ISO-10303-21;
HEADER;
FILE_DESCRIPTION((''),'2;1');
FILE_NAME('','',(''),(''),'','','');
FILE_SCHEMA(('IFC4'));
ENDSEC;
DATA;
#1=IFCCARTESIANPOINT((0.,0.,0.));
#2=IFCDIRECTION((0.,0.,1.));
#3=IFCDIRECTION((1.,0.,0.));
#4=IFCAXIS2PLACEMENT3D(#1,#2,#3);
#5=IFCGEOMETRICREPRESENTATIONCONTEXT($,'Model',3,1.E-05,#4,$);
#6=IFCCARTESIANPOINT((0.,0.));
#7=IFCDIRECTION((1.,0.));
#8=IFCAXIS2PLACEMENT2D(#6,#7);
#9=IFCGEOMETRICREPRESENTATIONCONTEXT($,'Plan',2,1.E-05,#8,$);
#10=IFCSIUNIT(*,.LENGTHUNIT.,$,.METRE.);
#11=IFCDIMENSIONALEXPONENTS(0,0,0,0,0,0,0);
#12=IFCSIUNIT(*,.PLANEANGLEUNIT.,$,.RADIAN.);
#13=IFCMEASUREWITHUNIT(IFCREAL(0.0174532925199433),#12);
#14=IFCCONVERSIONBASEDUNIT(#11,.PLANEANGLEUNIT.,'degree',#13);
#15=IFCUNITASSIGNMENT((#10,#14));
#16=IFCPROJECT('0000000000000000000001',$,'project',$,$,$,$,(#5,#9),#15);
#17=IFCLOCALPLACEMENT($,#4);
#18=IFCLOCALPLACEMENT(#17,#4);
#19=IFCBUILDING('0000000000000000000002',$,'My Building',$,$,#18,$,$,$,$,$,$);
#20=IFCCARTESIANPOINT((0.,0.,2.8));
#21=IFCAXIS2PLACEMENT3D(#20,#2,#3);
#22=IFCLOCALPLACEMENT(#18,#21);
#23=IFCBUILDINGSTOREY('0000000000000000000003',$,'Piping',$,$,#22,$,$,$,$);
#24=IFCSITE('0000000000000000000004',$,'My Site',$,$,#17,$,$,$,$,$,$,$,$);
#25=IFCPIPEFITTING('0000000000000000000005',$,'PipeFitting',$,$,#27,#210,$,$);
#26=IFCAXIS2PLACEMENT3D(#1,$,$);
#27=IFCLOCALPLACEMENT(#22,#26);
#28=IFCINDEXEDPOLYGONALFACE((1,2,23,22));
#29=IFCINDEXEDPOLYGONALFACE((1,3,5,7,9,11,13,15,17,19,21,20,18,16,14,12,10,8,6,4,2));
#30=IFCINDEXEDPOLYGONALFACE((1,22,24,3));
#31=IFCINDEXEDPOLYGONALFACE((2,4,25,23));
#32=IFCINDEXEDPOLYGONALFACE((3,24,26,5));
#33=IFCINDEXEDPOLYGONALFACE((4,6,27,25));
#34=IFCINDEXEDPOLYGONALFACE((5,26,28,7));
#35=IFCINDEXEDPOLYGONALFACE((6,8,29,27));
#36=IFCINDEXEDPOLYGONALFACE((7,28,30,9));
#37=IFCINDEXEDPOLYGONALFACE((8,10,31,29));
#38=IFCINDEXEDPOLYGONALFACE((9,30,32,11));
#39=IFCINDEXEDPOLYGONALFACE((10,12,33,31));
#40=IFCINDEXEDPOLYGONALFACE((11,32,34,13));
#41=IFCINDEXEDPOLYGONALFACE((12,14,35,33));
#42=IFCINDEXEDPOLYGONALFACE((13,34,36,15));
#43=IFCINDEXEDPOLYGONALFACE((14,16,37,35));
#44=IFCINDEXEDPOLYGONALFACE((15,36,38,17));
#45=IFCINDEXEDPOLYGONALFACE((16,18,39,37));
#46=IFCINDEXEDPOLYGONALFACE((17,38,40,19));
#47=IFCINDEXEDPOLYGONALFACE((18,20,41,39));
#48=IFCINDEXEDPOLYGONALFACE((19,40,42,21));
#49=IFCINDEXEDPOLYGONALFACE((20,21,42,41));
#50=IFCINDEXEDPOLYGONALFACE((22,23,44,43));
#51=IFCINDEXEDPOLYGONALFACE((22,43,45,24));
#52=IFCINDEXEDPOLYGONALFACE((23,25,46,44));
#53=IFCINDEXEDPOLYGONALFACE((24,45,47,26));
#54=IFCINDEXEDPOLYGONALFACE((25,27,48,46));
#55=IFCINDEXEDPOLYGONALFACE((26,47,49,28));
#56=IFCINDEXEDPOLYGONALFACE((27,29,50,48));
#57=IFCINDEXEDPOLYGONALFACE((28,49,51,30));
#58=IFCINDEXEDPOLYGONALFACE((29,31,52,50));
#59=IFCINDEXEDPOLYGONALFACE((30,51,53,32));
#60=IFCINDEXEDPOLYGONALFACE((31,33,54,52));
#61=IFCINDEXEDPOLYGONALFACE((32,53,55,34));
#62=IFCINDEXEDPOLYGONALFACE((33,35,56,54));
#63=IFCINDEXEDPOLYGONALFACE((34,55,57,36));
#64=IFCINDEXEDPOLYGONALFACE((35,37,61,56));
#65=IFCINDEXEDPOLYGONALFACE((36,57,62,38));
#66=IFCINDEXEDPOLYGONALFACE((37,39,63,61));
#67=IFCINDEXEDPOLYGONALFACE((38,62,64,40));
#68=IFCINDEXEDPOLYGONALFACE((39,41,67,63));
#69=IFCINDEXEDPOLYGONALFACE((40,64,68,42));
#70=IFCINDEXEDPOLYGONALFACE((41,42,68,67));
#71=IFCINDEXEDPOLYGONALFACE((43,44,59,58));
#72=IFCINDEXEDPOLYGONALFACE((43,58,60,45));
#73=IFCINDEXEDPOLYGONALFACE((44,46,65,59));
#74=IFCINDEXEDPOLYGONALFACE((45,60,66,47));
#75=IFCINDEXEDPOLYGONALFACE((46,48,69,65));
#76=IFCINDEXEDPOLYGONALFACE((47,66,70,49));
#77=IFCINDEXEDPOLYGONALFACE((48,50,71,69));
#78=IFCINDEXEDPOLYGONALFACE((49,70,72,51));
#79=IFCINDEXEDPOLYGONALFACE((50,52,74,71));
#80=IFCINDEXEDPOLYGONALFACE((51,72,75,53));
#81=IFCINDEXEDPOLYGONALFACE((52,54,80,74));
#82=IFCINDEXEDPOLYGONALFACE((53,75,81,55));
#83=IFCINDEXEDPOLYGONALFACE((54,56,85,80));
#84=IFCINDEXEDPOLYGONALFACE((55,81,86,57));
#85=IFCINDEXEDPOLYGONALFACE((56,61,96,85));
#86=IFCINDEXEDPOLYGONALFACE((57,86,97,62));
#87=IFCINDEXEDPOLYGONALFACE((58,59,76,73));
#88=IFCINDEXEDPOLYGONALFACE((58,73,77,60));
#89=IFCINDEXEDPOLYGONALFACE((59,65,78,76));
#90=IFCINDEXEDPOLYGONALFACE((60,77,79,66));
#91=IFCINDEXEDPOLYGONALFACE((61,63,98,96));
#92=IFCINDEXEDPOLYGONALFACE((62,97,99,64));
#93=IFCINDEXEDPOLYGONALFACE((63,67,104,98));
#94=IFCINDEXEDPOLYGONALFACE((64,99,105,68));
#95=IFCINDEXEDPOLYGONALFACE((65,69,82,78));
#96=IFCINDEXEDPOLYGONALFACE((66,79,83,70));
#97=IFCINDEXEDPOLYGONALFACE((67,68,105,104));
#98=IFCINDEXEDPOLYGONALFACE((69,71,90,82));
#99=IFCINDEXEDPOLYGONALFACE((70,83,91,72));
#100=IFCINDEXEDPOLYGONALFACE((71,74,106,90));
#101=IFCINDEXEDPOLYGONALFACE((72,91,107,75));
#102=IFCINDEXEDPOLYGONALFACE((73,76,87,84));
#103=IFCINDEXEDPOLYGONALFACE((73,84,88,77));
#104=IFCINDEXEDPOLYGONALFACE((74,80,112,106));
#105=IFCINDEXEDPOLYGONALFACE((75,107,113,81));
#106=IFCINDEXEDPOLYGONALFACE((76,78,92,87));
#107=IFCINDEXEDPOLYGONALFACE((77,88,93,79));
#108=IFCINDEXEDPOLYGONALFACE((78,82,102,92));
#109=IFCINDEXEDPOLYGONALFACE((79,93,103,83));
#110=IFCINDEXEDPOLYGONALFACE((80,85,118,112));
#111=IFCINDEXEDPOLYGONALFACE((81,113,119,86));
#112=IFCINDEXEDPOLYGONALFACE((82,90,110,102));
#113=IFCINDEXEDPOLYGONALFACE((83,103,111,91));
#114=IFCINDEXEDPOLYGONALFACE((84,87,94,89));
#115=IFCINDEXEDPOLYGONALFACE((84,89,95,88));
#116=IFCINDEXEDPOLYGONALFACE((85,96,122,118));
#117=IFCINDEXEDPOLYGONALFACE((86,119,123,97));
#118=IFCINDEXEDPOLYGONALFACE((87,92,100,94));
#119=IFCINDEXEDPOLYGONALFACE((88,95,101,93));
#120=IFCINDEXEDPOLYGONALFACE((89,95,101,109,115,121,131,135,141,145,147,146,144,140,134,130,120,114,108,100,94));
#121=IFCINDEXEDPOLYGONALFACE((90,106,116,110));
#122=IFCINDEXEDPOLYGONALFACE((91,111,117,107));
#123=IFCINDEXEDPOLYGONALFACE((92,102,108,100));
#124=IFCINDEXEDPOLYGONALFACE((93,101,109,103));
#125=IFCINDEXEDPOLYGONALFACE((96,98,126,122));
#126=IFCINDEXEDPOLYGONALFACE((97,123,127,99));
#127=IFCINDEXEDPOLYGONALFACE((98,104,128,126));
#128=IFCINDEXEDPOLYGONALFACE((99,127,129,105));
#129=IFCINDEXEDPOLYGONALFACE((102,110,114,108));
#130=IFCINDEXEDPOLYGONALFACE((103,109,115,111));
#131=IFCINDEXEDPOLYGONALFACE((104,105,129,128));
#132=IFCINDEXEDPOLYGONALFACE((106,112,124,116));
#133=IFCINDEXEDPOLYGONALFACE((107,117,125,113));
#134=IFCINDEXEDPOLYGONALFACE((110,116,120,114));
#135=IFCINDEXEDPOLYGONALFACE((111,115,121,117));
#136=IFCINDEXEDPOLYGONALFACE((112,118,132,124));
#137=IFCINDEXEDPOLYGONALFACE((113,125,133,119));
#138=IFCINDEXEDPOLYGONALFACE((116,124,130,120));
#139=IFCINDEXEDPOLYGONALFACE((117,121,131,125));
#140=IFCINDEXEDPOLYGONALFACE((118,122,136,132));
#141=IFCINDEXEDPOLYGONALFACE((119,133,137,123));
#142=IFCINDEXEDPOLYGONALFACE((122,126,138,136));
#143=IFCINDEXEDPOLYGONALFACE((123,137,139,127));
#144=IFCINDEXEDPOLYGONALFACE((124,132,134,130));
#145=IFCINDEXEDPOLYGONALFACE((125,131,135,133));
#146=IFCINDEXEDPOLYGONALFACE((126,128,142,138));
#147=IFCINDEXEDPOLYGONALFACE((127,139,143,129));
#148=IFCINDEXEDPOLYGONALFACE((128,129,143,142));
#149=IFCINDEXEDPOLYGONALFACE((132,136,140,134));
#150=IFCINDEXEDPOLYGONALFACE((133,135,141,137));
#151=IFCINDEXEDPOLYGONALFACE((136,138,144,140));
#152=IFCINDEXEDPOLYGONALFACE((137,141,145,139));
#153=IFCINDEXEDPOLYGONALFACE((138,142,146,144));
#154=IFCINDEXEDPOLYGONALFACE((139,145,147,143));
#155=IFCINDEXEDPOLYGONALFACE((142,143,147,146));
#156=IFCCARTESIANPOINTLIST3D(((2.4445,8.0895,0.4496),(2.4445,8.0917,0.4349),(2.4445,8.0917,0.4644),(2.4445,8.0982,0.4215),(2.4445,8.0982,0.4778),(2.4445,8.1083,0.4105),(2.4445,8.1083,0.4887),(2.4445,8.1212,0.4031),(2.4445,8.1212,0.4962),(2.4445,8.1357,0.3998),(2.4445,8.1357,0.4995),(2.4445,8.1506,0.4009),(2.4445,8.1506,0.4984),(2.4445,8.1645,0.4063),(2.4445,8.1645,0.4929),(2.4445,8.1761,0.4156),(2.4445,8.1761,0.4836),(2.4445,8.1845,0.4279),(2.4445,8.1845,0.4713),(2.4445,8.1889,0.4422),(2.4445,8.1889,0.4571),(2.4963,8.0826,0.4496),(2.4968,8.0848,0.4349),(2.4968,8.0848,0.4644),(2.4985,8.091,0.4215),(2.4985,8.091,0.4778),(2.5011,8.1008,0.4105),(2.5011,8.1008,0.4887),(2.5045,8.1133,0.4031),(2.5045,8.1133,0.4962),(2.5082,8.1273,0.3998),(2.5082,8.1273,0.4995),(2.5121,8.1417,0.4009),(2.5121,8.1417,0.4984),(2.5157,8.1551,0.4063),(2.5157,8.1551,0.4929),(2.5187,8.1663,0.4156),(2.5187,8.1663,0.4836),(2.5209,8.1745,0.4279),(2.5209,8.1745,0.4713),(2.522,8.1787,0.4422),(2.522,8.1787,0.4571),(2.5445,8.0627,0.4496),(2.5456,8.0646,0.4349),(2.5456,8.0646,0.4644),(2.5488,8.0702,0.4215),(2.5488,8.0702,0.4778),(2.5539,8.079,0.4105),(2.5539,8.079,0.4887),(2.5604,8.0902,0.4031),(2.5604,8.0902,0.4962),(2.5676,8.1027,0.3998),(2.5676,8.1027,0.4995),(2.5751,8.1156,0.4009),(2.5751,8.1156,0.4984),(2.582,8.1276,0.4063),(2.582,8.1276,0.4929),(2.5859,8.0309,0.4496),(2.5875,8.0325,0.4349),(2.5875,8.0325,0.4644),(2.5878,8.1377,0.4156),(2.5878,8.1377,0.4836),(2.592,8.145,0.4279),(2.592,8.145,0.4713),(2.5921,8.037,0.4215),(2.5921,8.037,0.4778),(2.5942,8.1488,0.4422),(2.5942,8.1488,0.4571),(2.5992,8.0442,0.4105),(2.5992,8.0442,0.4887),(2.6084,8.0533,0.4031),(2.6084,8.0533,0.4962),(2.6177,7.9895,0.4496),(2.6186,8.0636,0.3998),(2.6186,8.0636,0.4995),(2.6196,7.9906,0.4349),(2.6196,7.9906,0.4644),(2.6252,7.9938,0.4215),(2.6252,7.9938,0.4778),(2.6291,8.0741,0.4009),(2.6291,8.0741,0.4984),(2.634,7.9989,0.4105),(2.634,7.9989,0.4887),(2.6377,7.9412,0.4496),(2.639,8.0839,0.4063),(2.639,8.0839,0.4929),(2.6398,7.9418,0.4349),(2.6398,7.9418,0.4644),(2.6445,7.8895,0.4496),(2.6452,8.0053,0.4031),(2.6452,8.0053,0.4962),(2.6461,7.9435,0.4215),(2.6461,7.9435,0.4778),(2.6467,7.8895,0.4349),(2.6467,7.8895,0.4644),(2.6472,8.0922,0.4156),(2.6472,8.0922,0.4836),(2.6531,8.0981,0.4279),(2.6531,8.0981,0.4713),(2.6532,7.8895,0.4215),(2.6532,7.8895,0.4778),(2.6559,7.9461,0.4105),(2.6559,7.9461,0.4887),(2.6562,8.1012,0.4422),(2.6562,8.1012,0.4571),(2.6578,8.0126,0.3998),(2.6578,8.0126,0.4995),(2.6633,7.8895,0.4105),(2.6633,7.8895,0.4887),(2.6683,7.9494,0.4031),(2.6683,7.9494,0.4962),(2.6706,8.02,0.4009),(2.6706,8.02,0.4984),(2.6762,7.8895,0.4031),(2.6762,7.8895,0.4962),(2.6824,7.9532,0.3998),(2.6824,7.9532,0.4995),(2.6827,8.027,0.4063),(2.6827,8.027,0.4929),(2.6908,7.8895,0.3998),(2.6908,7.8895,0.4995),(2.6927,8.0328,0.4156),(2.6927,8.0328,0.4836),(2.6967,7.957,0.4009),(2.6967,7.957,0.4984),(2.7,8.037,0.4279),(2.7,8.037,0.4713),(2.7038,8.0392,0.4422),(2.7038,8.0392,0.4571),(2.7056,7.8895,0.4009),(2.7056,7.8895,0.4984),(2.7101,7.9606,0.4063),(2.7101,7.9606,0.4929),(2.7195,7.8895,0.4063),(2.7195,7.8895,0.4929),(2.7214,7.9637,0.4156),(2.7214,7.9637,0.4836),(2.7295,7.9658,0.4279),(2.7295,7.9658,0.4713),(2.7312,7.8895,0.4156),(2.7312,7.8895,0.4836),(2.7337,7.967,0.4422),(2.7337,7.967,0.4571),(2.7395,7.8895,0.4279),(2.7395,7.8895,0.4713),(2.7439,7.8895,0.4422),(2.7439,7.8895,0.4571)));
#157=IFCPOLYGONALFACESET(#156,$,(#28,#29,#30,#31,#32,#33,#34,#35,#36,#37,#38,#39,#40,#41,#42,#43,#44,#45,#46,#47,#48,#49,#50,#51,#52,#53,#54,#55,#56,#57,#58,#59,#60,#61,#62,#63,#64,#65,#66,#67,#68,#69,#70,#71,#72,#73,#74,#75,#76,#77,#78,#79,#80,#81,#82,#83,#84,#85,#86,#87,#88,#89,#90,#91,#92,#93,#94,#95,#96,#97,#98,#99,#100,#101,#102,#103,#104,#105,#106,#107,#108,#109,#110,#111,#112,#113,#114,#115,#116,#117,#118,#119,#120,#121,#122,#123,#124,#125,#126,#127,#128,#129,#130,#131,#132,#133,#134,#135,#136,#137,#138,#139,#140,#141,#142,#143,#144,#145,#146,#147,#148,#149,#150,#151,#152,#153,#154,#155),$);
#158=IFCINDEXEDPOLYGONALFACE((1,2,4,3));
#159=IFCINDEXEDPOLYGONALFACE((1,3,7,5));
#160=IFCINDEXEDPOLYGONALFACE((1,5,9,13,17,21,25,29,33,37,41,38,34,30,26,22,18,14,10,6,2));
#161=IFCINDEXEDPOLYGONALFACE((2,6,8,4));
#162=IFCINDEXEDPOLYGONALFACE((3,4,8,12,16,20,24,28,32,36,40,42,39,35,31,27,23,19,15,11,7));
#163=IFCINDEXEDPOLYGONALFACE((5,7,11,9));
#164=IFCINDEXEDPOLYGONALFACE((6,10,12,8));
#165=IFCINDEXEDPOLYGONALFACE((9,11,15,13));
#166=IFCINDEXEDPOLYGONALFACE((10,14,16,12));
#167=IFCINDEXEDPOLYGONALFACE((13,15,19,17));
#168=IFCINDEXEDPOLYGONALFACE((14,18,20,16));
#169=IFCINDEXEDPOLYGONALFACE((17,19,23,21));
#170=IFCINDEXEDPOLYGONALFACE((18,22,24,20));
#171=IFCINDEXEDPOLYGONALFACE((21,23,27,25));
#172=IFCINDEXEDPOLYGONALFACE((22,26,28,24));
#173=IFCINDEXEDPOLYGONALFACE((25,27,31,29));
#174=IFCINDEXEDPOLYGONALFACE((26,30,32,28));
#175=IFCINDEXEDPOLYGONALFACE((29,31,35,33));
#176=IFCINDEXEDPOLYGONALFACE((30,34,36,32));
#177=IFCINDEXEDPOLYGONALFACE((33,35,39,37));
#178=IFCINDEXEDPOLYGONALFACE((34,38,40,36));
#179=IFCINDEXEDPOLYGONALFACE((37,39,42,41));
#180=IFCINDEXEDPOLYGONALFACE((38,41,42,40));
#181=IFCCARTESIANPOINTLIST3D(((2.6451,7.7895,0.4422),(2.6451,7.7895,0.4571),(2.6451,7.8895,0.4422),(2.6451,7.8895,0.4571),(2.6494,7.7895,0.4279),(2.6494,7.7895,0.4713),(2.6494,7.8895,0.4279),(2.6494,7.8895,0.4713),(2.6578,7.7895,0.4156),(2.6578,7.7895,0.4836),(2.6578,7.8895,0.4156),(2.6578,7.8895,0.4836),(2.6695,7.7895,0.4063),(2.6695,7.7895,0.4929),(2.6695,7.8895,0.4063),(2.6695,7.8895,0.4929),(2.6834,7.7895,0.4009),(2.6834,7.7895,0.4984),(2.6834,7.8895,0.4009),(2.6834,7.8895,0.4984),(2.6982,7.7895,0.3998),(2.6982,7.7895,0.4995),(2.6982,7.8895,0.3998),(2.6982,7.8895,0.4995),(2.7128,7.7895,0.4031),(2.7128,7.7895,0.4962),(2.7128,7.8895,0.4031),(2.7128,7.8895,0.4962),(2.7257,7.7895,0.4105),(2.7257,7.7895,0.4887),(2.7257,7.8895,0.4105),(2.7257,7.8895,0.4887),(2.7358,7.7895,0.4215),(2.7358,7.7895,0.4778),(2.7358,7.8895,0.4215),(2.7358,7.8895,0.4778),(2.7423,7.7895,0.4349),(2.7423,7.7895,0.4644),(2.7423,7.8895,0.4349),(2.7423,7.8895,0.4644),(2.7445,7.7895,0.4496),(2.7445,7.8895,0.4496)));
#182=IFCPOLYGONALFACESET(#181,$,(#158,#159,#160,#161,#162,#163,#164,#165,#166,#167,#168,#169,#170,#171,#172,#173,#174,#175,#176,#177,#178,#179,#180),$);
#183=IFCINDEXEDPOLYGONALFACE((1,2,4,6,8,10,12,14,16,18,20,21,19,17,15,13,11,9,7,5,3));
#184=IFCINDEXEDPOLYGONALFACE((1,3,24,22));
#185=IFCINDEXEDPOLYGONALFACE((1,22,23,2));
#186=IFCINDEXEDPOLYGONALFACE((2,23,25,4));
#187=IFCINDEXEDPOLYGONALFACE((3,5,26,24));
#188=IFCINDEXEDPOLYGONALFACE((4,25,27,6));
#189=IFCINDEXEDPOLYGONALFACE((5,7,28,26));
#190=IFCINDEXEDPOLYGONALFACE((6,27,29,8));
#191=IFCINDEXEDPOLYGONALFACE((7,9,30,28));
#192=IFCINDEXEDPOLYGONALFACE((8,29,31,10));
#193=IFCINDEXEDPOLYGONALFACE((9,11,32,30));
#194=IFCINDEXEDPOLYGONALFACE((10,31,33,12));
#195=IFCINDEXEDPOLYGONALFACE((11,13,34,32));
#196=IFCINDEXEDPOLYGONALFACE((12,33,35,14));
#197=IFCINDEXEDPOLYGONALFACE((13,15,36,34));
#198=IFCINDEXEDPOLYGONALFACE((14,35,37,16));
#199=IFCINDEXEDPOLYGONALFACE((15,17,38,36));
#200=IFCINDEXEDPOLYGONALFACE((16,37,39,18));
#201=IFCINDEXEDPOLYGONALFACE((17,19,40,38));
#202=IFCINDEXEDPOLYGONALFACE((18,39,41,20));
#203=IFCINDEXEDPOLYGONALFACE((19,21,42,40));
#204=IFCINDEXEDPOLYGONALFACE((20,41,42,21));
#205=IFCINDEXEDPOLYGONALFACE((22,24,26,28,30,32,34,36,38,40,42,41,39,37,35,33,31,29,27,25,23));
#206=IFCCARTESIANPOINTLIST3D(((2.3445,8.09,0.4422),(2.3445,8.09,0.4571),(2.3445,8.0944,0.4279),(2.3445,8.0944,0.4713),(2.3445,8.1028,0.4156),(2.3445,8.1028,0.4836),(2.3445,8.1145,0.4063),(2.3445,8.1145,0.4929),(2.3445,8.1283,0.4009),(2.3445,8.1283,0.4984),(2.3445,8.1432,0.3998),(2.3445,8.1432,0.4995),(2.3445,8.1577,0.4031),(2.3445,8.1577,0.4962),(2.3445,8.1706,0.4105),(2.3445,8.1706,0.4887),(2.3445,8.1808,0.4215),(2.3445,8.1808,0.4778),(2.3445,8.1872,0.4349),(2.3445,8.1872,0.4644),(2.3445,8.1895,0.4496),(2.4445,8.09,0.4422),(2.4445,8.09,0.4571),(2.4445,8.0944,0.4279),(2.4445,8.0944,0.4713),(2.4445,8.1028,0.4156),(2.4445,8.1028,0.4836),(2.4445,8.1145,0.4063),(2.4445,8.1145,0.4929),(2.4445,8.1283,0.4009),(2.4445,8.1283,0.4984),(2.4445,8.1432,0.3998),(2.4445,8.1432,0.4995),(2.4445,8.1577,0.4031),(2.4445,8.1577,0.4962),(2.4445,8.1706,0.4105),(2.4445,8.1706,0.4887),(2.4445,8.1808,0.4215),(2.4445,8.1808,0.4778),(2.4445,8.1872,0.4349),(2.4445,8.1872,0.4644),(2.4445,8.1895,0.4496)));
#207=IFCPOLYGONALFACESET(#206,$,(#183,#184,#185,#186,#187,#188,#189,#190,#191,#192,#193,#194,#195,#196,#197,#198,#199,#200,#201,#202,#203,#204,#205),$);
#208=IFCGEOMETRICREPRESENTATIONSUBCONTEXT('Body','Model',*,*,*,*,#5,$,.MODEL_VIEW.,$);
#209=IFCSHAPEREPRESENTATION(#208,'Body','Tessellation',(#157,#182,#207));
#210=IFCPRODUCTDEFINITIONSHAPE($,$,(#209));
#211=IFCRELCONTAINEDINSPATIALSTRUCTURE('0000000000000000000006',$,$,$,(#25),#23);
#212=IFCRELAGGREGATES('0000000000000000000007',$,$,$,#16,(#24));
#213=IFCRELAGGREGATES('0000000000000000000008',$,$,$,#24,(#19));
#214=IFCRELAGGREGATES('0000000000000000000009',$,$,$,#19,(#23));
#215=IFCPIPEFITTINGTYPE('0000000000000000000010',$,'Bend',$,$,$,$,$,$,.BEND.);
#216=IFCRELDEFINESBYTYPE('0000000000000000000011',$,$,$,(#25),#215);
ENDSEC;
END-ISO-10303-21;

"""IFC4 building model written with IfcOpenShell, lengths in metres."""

from ifc_helpers import new_model, entity, si_unit, converted_unit, frame, origin_with_axes, origin_2d_with_axis, place, context, subcontext, project, spatial, circle, extrude, source, transform, mapped, type_object, type_shapes, element, save


model = new_model("IFC4")

# Units and contexts
model_context = context("Model", 3, precision=1e-05, world=origin_with_axes())
plan_context = context("Plan", 2, precision=1e-05, world=origin_2d_with_axis())
body_context = subcontext(model_context, "Body", "Model", "MODEL_VIEW")
ifc_project = project(units=[si_unit("LENGTHUNIT", "METRE"), converted_unit("PLANEANGLEUNIT", "degree", entity("IfcReal", 0.0174532925199433), si_unit("PLANEANGLEUNIT", "RADIAN"), dimensions=[0, 0, 0, 0, 0, 0, 0])], contexts=[model_context, plan_context])

# Site, building, storey
site_placement = place(None, origin_with_axes())
site = spatial("IfcSite", under=ifc_project, at=site_placement, Name="My Site")
building_placement = place(site_placement, origin_with_axes())
building = spatial("IfcBuilding", under=site, at=building_placement, Name="My Building")
storey_placement = place(building_placement, frame((0.0, 0.0, 2.8), z_axis=(0.0, 0.0, 1.0), x_axis=(1.0, 0.0, 0.0)))
storey = spatial("IfcBuildingStorey", under=building, at=storey_placement, Name="Piping")

# Pipe fitting
pipe_fitting_type_1 = type_object("IfcPipeFittingType", Name="Bend", PredefinedType="BEND")
shared_shape_1 = source(origin_with_axes(), body_context, "Body", "SolidModel", [
    entity("IfcSweptDiskSolid", entity("IfcIndexedPolyCurve", entity("IfcCartesianPointList3D", [[0.0, 0.0, -0.1], [-0.0732, 0.0, -0.2768], [-0.25, 0.0, -0.35]]), [entity("IfcArcIndex", [1, 2, 3])]), 0.05),
    extrude(circle(Radius=0.05), origin_with_axes(), (0.0, 0.0, -1.0), 0.1),
    extrude(circle(Radius=0.05), frame((-0.25, 0.0, -0.35), z_axis=(-1.0, 0.0, 0.0), x_axis=(0.0, 0.0, -1.0)), (0.0, 0.0, 1.0), 0.1),
])
type_shapes(pipe_fitting_type_1, [shared_shape_1])
for number, where, z_axis, x_axis, name in (
    (1, (2.6945, 7.7895, 0.4496), (0.0, -1.0, 0.0), (1.0, 0.0, 0.0), "PipeFitting"),
):
    element("IfcPipeFitting", number, at=place(storey_placement, frame(where, z_axis=z_axis, x_axis=x_axis)), inside=storey, type_object=pipe_fitting_type_1, Name=name, context=body_context, shape_type="MappedRepresentation", body=[
        mapped(shared_shape_1, transform((0.0, 0.0, 0.0), x_axis=(1.0, 0.0, 0.0), y_axis=(0.0, 1.0, 0.0), z_axis=(0.0, 0.0, 1.0), scale=1.0)),
    ])

save(model, "model.ifc")
